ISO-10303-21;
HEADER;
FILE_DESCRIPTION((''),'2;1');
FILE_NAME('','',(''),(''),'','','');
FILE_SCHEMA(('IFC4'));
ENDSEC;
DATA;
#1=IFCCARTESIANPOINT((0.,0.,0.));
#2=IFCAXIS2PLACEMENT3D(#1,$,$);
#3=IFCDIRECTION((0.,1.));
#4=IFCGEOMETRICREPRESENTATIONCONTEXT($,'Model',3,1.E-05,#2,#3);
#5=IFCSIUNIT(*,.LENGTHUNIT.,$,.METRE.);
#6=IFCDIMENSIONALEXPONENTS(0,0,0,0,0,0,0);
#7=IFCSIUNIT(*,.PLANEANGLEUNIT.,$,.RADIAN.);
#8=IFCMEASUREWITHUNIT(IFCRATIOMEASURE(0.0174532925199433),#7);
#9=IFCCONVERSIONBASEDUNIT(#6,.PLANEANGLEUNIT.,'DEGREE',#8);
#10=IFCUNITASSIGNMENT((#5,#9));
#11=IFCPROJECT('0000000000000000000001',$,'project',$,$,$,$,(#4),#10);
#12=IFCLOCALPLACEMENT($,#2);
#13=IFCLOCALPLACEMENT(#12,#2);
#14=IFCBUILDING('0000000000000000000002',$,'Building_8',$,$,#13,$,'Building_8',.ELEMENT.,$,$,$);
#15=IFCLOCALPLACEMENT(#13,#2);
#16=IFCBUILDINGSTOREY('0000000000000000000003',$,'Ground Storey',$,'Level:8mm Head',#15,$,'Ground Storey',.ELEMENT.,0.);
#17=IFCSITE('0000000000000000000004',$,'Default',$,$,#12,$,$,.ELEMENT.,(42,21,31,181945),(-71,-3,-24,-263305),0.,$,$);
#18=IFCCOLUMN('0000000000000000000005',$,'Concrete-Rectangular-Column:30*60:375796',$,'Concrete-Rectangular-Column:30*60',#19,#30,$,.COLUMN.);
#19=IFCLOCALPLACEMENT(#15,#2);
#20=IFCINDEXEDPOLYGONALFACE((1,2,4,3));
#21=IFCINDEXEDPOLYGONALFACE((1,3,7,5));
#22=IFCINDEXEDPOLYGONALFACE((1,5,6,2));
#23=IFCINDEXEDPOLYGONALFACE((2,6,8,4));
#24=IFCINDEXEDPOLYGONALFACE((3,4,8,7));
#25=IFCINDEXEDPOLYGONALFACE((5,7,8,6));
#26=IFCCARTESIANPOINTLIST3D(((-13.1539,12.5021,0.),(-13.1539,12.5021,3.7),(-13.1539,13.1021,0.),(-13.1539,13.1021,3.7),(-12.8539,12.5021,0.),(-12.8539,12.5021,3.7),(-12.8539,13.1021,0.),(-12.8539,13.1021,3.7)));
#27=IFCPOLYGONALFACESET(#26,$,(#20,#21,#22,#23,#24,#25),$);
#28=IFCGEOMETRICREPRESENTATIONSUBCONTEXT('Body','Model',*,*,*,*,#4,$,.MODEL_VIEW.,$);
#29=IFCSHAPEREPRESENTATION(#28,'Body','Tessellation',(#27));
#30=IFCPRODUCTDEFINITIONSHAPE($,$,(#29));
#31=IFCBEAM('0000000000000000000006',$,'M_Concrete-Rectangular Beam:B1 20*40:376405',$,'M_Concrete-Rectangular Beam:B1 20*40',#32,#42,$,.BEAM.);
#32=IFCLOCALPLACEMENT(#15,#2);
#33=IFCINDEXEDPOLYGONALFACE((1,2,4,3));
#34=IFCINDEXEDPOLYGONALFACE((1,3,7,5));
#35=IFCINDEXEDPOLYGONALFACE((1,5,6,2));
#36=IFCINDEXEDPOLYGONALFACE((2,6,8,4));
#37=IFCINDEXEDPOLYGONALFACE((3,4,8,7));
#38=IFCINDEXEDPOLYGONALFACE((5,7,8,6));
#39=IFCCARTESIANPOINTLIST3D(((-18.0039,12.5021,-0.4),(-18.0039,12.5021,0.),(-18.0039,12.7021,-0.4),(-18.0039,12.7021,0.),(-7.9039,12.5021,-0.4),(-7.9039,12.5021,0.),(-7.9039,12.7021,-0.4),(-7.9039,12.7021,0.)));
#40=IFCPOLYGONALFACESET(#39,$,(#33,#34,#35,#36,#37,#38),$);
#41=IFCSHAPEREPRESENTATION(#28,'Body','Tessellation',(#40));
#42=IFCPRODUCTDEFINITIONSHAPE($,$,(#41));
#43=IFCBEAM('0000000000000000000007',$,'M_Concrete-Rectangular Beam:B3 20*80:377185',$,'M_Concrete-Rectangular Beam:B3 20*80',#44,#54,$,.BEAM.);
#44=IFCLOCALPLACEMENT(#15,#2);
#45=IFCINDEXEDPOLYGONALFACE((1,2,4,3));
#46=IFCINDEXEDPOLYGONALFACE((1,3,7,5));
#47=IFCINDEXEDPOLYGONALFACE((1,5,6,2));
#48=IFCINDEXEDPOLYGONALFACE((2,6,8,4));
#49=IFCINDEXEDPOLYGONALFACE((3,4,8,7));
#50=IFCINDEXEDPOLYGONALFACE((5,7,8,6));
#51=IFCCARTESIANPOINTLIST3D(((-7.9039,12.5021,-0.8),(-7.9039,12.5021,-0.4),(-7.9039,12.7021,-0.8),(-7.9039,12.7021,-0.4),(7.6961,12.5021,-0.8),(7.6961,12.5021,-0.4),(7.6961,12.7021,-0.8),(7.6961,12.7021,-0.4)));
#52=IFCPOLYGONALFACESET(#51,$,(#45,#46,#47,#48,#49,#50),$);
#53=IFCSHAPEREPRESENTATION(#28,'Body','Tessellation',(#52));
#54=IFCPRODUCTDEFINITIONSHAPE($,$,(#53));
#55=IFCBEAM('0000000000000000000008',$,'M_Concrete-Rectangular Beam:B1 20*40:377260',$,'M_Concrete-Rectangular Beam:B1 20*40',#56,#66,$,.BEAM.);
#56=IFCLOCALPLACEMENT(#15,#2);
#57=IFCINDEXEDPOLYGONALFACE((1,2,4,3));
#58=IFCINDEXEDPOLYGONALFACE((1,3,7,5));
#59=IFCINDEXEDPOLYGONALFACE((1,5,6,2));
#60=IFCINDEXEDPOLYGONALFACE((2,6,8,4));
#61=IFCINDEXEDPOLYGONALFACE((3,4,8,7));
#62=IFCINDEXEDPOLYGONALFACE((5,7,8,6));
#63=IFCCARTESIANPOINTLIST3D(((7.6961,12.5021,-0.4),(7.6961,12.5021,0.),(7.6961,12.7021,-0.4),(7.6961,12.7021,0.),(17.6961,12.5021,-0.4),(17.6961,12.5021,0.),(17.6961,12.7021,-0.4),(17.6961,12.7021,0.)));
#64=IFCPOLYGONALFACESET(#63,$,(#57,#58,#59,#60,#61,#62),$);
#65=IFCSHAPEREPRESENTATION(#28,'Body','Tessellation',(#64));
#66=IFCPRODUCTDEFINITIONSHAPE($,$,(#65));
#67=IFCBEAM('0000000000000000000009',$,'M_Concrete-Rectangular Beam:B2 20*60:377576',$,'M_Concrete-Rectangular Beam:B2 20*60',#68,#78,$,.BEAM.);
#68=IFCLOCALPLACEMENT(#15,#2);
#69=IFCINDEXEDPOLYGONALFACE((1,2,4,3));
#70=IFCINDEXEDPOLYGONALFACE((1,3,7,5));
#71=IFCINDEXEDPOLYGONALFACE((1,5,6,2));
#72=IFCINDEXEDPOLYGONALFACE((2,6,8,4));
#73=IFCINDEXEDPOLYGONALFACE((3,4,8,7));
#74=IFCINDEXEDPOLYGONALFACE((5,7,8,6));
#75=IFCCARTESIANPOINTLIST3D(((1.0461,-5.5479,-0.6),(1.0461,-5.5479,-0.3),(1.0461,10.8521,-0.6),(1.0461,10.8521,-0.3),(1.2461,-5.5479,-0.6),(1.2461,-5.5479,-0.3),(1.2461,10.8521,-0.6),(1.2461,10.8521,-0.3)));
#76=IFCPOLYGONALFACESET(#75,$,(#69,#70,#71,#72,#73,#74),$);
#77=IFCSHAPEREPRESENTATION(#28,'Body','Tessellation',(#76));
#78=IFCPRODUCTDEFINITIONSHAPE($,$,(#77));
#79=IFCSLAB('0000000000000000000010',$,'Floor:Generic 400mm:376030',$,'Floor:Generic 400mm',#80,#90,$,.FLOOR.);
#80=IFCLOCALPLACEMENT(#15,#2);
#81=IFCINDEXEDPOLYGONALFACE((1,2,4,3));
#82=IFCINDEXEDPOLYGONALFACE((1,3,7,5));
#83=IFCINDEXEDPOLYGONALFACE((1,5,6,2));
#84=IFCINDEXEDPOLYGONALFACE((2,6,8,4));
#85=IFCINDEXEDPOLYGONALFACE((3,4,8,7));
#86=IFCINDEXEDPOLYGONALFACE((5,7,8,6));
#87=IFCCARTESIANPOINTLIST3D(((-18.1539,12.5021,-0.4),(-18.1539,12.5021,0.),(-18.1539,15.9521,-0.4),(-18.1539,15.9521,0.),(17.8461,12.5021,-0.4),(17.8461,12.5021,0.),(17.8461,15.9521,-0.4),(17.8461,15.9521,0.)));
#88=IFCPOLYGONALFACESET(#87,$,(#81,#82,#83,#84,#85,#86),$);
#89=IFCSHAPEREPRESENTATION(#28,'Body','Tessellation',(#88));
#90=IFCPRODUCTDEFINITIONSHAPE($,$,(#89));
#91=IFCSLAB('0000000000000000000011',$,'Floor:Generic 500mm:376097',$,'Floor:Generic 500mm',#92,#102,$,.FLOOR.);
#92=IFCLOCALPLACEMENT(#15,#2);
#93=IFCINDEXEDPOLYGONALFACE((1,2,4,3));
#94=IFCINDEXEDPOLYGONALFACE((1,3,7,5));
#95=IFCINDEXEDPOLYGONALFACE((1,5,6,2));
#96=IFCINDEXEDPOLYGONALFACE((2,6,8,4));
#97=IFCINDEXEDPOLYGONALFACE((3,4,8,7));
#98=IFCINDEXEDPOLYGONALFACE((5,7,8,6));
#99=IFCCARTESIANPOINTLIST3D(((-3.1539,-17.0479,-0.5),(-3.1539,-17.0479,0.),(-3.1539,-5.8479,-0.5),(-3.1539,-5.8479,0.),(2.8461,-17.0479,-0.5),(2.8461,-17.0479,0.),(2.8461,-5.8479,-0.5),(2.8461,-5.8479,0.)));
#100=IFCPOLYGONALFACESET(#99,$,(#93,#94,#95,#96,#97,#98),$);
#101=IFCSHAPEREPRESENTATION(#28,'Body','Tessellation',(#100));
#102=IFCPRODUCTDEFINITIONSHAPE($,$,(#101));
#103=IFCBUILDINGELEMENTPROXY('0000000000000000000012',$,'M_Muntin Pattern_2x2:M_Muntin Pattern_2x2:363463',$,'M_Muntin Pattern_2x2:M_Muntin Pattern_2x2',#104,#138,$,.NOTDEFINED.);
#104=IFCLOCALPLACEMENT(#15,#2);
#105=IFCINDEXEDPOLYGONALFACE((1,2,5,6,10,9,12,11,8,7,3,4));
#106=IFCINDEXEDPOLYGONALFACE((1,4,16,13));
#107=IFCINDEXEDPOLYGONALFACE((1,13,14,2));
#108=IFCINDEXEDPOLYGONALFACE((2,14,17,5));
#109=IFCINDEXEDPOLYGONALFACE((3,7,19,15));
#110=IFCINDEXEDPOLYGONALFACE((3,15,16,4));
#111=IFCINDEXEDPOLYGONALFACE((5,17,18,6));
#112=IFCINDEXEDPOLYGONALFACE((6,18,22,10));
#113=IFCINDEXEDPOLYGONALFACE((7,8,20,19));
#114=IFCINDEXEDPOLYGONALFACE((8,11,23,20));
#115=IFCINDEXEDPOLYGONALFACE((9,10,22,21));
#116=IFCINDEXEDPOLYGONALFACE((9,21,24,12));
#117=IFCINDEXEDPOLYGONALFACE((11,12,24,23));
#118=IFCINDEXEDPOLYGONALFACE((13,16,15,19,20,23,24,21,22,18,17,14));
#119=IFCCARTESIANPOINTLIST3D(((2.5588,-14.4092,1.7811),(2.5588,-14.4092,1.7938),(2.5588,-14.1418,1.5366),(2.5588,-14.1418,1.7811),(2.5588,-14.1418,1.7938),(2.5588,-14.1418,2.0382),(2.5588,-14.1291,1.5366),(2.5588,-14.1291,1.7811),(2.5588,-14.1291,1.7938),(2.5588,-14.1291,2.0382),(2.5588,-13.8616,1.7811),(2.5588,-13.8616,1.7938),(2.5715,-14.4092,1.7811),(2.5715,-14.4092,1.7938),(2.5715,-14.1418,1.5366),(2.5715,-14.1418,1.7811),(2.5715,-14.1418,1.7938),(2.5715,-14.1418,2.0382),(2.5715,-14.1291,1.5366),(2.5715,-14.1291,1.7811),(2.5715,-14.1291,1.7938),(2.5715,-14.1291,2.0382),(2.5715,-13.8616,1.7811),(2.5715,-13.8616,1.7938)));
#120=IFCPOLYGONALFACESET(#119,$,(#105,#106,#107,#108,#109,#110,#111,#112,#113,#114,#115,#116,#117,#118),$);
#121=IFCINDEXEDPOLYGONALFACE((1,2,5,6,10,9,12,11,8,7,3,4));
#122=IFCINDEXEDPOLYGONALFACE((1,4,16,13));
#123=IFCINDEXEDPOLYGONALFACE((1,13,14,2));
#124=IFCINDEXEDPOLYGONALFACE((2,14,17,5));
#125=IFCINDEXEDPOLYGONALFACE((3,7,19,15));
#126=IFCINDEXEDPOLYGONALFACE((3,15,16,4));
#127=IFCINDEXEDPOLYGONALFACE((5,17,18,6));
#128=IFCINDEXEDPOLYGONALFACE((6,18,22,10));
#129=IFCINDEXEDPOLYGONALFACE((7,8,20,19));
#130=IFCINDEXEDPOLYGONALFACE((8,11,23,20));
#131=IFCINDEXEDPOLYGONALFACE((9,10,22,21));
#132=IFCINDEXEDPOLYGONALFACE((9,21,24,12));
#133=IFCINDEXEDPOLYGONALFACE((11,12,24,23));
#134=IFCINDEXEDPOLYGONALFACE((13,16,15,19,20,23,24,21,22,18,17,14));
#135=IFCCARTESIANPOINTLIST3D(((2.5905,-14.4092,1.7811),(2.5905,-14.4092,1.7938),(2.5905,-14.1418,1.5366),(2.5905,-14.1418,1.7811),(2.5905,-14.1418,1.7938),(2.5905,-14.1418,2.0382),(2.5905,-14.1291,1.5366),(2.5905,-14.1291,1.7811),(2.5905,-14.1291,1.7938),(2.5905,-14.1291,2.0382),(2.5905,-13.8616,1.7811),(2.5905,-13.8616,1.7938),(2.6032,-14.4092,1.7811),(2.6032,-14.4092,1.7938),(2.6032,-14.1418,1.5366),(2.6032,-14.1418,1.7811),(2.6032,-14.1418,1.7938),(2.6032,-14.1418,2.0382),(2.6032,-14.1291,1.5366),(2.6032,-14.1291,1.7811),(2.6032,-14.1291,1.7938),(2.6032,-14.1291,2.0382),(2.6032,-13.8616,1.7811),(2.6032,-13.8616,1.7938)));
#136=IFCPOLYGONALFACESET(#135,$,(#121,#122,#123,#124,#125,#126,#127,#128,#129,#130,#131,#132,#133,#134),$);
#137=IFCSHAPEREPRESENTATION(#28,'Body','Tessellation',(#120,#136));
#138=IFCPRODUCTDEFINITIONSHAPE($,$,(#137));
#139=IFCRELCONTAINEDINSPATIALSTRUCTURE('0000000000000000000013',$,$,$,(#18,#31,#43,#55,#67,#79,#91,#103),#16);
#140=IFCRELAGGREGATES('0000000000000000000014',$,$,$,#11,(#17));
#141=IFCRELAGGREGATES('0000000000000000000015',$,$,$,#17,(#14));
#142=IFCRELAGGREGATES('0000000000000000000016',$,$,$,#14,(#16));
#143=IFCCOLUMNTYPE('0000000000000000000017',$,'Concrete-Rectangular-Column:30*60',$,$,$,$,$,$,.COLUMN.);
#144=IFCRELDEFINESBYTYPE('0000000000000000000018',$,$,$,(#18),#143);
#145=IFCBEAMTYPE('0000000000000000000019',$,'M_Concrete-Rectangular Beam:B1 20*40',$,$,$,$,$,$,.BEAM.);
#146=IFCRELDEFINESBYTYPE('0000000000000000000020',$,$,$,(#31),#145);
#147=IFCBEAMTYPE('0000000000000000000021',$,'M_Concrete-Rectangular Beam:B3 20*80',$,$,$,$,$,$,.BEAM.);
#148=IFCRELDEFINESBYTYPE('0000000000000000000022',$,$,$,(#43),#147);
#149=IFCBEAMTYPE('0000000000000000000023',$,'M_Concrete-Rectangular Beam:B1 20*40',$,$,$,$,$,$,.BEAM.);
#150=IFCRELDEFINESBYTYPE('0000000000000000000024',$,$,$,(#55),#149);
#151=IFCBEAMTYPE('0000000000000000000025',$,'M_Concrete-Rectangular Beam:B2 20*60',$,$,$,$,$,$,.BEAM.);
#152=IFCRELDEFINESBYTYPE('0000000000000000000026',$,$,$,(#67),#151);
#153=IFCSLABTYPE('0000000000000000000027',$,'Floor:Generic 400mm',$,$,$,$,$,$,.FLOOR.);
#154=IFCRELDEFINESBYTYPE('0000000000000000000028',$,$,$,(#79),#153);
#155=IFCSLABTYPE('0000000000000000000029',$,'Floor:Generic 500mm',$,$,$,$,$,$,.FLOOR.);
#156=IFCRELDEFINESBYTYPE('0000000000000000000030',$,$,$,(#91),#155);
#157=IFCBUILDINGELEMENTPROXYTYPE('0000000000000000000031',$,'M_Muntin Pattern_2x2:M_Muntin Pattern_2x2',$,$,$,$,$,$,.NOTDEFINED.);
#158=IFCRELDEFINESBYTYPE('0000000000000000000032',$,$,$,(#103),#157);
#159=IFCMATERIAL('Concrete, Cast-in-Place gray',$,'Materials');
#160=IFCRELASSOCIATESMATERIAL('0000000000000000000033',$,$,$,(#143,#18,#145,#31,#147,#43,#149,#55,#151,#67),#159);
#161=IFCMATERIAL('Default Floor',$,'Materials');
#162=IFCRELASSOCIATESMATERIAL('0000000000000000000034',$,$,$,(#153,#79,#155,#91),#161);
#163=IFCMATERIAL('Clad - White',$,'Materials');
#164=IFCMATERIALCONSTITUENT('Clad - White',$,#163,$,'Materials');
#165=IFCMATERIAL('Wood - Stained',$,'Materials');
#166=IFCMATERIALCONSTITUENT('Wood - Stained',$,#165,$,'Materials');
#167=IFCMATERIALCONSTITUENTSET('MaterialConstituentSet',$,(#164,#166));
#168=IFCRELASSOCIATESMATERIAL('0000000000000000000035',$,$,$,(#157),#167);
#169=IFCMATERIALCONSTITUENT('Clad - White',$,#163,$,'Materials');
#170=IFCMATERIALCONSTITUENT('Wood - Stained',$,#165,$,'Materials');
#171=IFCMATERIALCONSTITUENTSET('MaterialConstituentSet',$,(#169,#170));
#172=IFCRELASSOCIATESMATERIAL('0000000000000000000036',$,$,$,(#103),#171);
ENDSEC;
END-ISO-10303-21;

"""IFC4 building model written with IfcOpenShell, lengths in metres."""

from ifc_helpers import new_model, entity, si_unit, converted_unit, direction, frame, origin, place, context, subcontext, project, spatial, indexed_curve, outline, extrude, source, transform, mapped, material, constituent, constituent_set, type_object, type_shapes, element, save


model = new_model("IFC4")

# Units and contexts
model_context = context("Model", 3, precision=1e-05, world=origin(), true_north=direction((0.0, 1.0)))
body_context = subcontext(model_context, "Body", "Model", "MODEL_VIEW")
ifc_project = project(units=[si_unit("LENGTHUNIT", "METRE"), converted_unit("PLANEANGLEUNIT", "DEGREE", entity("IfcRatioMeasure", 0.0174532925199433), si_unit("PLANEANGLEUNIT", "RADIAN"), dimensions=[0, 0, 0, 0, 0, 0, 0])], contexts=[model_context])

# Site, building, storey
site_placement = place(None, origin())
site = spatial("IfcSite", under=ifc_project, at=site_placement, Name="Default", CompositionType="ELEMENT", RefLatitude=(42, 21, 31, 181945), RefLongitude=(-71, -3, -24, -263305), RefElevation=0.0)
building_placement = place(site_placement, origin())
building = spatial("IfcBuilding", under=site, at=building_placement, Name="Building_8", LongName="Building_8", CompositionType="ELEMENT")
storey_placement = place(building_placement, origin())
storey = spatial("IfcBuildingStorey", under=building, at=storey_placement, Name="Ground Storey", ObjectType="Level:8mm Head", LongName="Ground Storey", CompositionType="ELEMENT", Elevation=0.0)

# Column
ifc_material_1 = material(Name="Concrete, Cast-in-Place gray", Category="Materials")
column_type = type_object("IfcColumnType", Name="Concrete-Rectangular-Column:30*60", PredefinedType="COLUMN", material=ifc_material_1)
shared_shape_1 = source(origin(), body_context, "Body", "SweptSolid", [
    extrude(outline(indexed_curve([(-0.3, -0.15), (0.3, -0.15), (0.3, 0.15), (-0.3, 0.15), (-0.3, -0.15)], self_intersect=False)), frame((-13.0039, 12.8021, 0.0), z_axis=(0.0, 0.0, 1.0), x_axis=(0.0, -1.0, 0.0)), (0.0, 0.0, 1.0), 3.7),
])
type_shapes(column_type, [shared_shape_1])
column_placement = place(storey_placement, origin())
element("IfcColumn", 1, at=column_placement, inside=storey, type_object=column_type, material=ifc_material_1, Name="Concrete-Rectangular-Column:30*60:375796", ObjectType="Concrete-Rectangular-Column:30*60", PredefinedType="COLUMN", context=body_context, shape_type="MappedRepresentation", body=[
    mapped(shared_shape_1, transform((0.0, 0.0, 0.0), scale=1.0)),
])

# Beams
beam_type_1 = type_object("IfcBeamType", Name="M_Concrete-Rectangular Beam:B1 20*40", PredefinedType="BEAM", material=ifc_material_1)
shared_shape_2 = source(origin(), body_context, "Body", "SweptSolid", [
    extrude(outline(indexed_curve([(-0.2, -0.1), (0.2, -0.1), (0.2, 0.1), (-0.2, 0.1), (-0.2, -0.1)], self_intersect=False)), frame((-18.0039, 12.6021, -0.2), z_axis=(1.0, 0.0, 0.0), x_axis=(0.0, 0.0, -1.0)), (0.0, 0.0, 1.0), 10.1),
])
type_shapes(beam_type_1, [shared_shape_2])
beam_1_placement = place(storey_placement, origin())
element("IfcBeam", 2, at=beam_1_placement, inside=storey, type_object=beam_type_1, material=ifc_material_1, Name="M_Concrete-Rectangular Beam:B1 20*40:376405", ObjectType="M_Concrete-Rectangular Beam:B1 20*40", PredefinedType="BEAM", context=body_context, shape_type="MappedRepresentation", body=[
    mapped(shared_shape_2, transform((0.0, 0.0, 0.0), scale=1.0)),
])
beam_type_2 = type_object("IfcBeamType", Name="M_Concrete-Rectangular Beam:B3 20*80", PredefinedType="BEAM", material=ifc_material_1)
shared_shape_3 = source(origin(), body_context, "Body", "SweptSolid", [
    extrude(outline(indexed_curve([(-0.2, -0.1), (0.2, -0.1), (0.2, 0.1), (-0.2, 0.1), (-0.2, -0.1)], self_intersect=False)), frame((-7.9039, 12.6021, -0.6), z_axis=(1.0, 0.0, 0.0), x_axis=(0.0, 0.0, -1.0)), (0.0, 0.0, 1.0), 15.6),
])
type_shapes(beam_type_2, [shared_shape_3])
beam_2_placement = place(storey_placement, origin())
element("IfcBeam", 3, at=beam_2_placement, inside=storey, type_object=beam_type_2, material=ifc_material_1, Name="M_Concrete-Rectangular Beam:B3 20*80:377185", ObjectType="M_Concrete-Rectangular Beam:B3 20*80", PredefinedType="BEAM", context=body_context, shape_type="MappedRepresentation", body=[
    mapped(shared_shape_3, transform((0.0, 0.0, 0.0), scale=1.0)),
])
beam_type_3 = type_object("IfcBeamType", Name="M_Concrete-Rectangular Beam:B1 20*40", PredefinedType="BEAM", material=ifc_material_1)
shared_shape_4 = source(origin(), body_context, "Body", "SweptSolid", [
    extrude(outline(indexed_curve([(-0.2, -0.1), (0.2, -0.1), (0.2, 0.1), (-0.2, 0.1), (-0.2, -0.1)], self_intersect=False)), frame((7.6961, 12.6021, -0.2), z_axis=(1.0, 0.0, 0.0), x_axis=(0.0, 0.0, -1.0)), (0.0, 0.0, 1.0), 10.0),
])
type_shapes(beam_type_3, [shared_shape_4])
beam_3_placement = place(storey_placement, origin())
element("IfcBeam", 4, at=beam_3_placement, inside=storey, type_object=beam_type_3, material=ifc_material_1, Name="M_Concrete-Rectangular Beam:B1 20*40:377260", ObjectType="M_Concrete-Rectangular Beam:B1 20*40", PredefinedType="BEAM", context=body_context, shape_type="MappedRepresentation", body=[
    mapped(shared_shape_4, transform((0.0, 0.0, 0.0), scale=1.0)),
])
beam_type_4 = type_object("IfcBeamType", Name="M_Concrete-Rectangular Beam:B2 20*60", PredefinedType="BEAM", material=ifc_material_1)
shared_shape_5 = source(origin(), body_context, "Body", "SweptSolid", [
    extrude(outline(indexed_curve([(-0.1, -0.15), (0.1, -0.15), (0.1, 0.15), (-0.1, 0.15), (-0.1, -0.15)], self_intersect=False)), frame((1.1461, 10.8521, -0.45), z_axis=(0.0, -1.0, 0.0), x_axis=(-1.0, 0.0, 0.0)), (0.0, 0.0, 1.0), 16.4),
])
type_shapes(beam_type_4, [shared_shape_5])
beam_4_placement = place(storey_placement, origin())
element("IfcBeam", 5, at=beam_4_placement, inside=storey, type_object=beam_type_4, material=ifc_material_1, Name="M_Concrete-Rectangular Beam:B2 20*60:377576", ObjectType="M_Concrete-Rectangular Beam:B2 20*60", PredefinedType="BEAM", context=body_context, shape_type="MappedRepresentation", body=[
    mapped(shared_shape_5, transform((0.0, 0.0, 0.0), scale=1.0)),
])

# Slabs
ifc_material_2 = material(Name="Default Floor", Category="Materials")
slab_type_1 = type_object("IfcSlabType", Name="Floor:Generic 400mm", PredefinedType="FLOOR", material=ifc_material_2)
slab_1_placement = place(storey_placement, origin())
element("IfcSlab", 6, at=slab_1_placement, inside=storey, type_object=slab_type_1, material=ifc_material_2, Name="Floor:Generic 400mm:376030", ObjectType="Floor:Generic 400mm", PredefinedType="FLOOR", context=body_context, shape_type="SweptSolid", body=[
    extrude(outline(indexed_curve([(-1.725, -18.0), (1.725, -18.0), (1.725, 18.0), (-1.725, 18.0), (-1.725, -18.0)], self_intersect=False)), frame((-0.1539, 14.2271, 0.0), z_axis=(0.0, 0.0, -1.0), x_axis=(0.0, 1.0, 0.0)), (0.0, 0.0, 1.0), 0.4),
])
slab_type_2 = type_object("IfcSlabType", Name="Floor:Generic 500mm", PredefinedType="FLOOR", material=ifc_material_2)
slab_2_placement = place(storey_placement, origin())
element("IfcSlab", 7, at=slab_2_placement, inside=storey, type_object=slab_type_2, material=ifc_material_2, Name="Floor:Generic 500mm:376097", ObjectType="Floor:Generic 500mm", PredefinedType="FLOOR", context=body_context, shape_type="SweptSolid", body=[
    extrude(outline(indexed_curve([(-5.6, -3.0), (5.6, -3.0), (5.6, 3.0), (-5.6, 3.0), (-5.6, -3.0)], self_intersect=False)), frame((-0.1539, -11.4479, 0.0), z_axis=(0.0, 0.0, -1.0), x_axis=(0.0, 1.0, 0.0)), (0.0, 0.0, 1.0), 0.5),
])

# Building element proxy
ifc_material_3 = material(Name="Clad - White", Category="Materials")
ifc_constituent_1 = constituent(ifc_material_3, Name="Clad - White", Category="Materials")
ifc_material_4 = material(Name="Wood - Stained", Category="Materials")
ifc_constituent_2 = constituent(ifc_material_4, Name="Wood - Stained", Category="Materials")
ifc_constituent_set_1 = constituent_set(constituents=[ifc_constituent_1, ifc_constituent_2], Name="MaterialConstituentSet")
ifc_constituent_3 = constituent(ifc_material_3, Name="Clad - White", Category="Materials")
ifc_constituent_4 = constituent(ifc_material_4, Name="Wood - Stained", Category="Materials")
ifc_constituent_set_2 = constituent_set(constituents=[ifc_constituent_3, ifc_constituent_4], Name="MaterialConstituentSet")
building_element_proxy_type_1 = type_object("IfcBuildingElementProxyType", Name="M_Muntin Pattern_2x2:M_Muntin Pattern_2x2", PredefinedType="NOTDEFINED", material=ifc_constituent_set_2)
shared_shape_6 = source(origin(), body_context, "Body", "SweptSolid", [
    extrude(outline(indexed_curve([(0.0064, -0.0064), (0.2508, -0.0064), (0.2508, 0.0063), (0.0064, 0.0063), (0.0064, 0.2738), (-0.0063, 0.2738), (-0.0063, 0.0063), (-0.2508, 0.0063), (-0.2508, -0.0064), (-0.0063, -0.0064), (-0.0063, -0.2738), (0.0064, -0.2738), (0.0064, -0.0064)], self_intersect=False)), frame((0.0, 0.0095, 0.2508), z_axis=(0.0, 1.0, 0.0), x_axis=(0.0, 0.0, 1.0)), (0.0, 0.0, 1.0), 0.0127),
    extrude(outline(indexed_curve([(0.0064, -0.0064), (0.2508, -0.0064), (0.2508, 0.0063), (0.0064, 0.0063), (0.0064, 0.2738), (-0.0063, 0.2738), (-0.0063, 0.0063), (-0.2508, 0.0063), (-0.2508, -0.0064), (-0.0063, -0.0064), (-0.0063, -0.2738), (0.0064, -0.2738), (0.0064, -0.0064)], self_intersect=False)), frame((0.0, -0.0222, 0.2508), z_axis=(0.0, 1.0, 0.0), x_axis=(0.0, 0.0, 1.0)), (0.0, 0.0, 1.0), 0.0127),
])
type_shapes(building_element_proxy_type_1, [shared_shape_6])
proxy_1_placement = place(storey_placement, frame((2.581, -14.1354, 1.5366), z_axis=(0.0, 0.0, 1.0), x_axis=(0.0, 1.0, 0.0)))
element("IfcBuildingElementProxy", 8, at=proxy_1_placement, inside=storey, type_object=building_element_proxy_type_1, material=ifc_constituent_set_1, Name="M_Muntin Pattern_2x2:M_Muntin Pattern_2x2:363463", ObjectType="M_Muntin Pattern_2x2:M_Muntin Pattern_2x2", PredefinedType="NOTDEFINED", context=body_context, shape_type="MappedRepresentation", body=[
    mapped(shared_shape_6, transform((0.0, 0.0, 0.0), scale=1.0)),
])

save(model, "model.ifc")
